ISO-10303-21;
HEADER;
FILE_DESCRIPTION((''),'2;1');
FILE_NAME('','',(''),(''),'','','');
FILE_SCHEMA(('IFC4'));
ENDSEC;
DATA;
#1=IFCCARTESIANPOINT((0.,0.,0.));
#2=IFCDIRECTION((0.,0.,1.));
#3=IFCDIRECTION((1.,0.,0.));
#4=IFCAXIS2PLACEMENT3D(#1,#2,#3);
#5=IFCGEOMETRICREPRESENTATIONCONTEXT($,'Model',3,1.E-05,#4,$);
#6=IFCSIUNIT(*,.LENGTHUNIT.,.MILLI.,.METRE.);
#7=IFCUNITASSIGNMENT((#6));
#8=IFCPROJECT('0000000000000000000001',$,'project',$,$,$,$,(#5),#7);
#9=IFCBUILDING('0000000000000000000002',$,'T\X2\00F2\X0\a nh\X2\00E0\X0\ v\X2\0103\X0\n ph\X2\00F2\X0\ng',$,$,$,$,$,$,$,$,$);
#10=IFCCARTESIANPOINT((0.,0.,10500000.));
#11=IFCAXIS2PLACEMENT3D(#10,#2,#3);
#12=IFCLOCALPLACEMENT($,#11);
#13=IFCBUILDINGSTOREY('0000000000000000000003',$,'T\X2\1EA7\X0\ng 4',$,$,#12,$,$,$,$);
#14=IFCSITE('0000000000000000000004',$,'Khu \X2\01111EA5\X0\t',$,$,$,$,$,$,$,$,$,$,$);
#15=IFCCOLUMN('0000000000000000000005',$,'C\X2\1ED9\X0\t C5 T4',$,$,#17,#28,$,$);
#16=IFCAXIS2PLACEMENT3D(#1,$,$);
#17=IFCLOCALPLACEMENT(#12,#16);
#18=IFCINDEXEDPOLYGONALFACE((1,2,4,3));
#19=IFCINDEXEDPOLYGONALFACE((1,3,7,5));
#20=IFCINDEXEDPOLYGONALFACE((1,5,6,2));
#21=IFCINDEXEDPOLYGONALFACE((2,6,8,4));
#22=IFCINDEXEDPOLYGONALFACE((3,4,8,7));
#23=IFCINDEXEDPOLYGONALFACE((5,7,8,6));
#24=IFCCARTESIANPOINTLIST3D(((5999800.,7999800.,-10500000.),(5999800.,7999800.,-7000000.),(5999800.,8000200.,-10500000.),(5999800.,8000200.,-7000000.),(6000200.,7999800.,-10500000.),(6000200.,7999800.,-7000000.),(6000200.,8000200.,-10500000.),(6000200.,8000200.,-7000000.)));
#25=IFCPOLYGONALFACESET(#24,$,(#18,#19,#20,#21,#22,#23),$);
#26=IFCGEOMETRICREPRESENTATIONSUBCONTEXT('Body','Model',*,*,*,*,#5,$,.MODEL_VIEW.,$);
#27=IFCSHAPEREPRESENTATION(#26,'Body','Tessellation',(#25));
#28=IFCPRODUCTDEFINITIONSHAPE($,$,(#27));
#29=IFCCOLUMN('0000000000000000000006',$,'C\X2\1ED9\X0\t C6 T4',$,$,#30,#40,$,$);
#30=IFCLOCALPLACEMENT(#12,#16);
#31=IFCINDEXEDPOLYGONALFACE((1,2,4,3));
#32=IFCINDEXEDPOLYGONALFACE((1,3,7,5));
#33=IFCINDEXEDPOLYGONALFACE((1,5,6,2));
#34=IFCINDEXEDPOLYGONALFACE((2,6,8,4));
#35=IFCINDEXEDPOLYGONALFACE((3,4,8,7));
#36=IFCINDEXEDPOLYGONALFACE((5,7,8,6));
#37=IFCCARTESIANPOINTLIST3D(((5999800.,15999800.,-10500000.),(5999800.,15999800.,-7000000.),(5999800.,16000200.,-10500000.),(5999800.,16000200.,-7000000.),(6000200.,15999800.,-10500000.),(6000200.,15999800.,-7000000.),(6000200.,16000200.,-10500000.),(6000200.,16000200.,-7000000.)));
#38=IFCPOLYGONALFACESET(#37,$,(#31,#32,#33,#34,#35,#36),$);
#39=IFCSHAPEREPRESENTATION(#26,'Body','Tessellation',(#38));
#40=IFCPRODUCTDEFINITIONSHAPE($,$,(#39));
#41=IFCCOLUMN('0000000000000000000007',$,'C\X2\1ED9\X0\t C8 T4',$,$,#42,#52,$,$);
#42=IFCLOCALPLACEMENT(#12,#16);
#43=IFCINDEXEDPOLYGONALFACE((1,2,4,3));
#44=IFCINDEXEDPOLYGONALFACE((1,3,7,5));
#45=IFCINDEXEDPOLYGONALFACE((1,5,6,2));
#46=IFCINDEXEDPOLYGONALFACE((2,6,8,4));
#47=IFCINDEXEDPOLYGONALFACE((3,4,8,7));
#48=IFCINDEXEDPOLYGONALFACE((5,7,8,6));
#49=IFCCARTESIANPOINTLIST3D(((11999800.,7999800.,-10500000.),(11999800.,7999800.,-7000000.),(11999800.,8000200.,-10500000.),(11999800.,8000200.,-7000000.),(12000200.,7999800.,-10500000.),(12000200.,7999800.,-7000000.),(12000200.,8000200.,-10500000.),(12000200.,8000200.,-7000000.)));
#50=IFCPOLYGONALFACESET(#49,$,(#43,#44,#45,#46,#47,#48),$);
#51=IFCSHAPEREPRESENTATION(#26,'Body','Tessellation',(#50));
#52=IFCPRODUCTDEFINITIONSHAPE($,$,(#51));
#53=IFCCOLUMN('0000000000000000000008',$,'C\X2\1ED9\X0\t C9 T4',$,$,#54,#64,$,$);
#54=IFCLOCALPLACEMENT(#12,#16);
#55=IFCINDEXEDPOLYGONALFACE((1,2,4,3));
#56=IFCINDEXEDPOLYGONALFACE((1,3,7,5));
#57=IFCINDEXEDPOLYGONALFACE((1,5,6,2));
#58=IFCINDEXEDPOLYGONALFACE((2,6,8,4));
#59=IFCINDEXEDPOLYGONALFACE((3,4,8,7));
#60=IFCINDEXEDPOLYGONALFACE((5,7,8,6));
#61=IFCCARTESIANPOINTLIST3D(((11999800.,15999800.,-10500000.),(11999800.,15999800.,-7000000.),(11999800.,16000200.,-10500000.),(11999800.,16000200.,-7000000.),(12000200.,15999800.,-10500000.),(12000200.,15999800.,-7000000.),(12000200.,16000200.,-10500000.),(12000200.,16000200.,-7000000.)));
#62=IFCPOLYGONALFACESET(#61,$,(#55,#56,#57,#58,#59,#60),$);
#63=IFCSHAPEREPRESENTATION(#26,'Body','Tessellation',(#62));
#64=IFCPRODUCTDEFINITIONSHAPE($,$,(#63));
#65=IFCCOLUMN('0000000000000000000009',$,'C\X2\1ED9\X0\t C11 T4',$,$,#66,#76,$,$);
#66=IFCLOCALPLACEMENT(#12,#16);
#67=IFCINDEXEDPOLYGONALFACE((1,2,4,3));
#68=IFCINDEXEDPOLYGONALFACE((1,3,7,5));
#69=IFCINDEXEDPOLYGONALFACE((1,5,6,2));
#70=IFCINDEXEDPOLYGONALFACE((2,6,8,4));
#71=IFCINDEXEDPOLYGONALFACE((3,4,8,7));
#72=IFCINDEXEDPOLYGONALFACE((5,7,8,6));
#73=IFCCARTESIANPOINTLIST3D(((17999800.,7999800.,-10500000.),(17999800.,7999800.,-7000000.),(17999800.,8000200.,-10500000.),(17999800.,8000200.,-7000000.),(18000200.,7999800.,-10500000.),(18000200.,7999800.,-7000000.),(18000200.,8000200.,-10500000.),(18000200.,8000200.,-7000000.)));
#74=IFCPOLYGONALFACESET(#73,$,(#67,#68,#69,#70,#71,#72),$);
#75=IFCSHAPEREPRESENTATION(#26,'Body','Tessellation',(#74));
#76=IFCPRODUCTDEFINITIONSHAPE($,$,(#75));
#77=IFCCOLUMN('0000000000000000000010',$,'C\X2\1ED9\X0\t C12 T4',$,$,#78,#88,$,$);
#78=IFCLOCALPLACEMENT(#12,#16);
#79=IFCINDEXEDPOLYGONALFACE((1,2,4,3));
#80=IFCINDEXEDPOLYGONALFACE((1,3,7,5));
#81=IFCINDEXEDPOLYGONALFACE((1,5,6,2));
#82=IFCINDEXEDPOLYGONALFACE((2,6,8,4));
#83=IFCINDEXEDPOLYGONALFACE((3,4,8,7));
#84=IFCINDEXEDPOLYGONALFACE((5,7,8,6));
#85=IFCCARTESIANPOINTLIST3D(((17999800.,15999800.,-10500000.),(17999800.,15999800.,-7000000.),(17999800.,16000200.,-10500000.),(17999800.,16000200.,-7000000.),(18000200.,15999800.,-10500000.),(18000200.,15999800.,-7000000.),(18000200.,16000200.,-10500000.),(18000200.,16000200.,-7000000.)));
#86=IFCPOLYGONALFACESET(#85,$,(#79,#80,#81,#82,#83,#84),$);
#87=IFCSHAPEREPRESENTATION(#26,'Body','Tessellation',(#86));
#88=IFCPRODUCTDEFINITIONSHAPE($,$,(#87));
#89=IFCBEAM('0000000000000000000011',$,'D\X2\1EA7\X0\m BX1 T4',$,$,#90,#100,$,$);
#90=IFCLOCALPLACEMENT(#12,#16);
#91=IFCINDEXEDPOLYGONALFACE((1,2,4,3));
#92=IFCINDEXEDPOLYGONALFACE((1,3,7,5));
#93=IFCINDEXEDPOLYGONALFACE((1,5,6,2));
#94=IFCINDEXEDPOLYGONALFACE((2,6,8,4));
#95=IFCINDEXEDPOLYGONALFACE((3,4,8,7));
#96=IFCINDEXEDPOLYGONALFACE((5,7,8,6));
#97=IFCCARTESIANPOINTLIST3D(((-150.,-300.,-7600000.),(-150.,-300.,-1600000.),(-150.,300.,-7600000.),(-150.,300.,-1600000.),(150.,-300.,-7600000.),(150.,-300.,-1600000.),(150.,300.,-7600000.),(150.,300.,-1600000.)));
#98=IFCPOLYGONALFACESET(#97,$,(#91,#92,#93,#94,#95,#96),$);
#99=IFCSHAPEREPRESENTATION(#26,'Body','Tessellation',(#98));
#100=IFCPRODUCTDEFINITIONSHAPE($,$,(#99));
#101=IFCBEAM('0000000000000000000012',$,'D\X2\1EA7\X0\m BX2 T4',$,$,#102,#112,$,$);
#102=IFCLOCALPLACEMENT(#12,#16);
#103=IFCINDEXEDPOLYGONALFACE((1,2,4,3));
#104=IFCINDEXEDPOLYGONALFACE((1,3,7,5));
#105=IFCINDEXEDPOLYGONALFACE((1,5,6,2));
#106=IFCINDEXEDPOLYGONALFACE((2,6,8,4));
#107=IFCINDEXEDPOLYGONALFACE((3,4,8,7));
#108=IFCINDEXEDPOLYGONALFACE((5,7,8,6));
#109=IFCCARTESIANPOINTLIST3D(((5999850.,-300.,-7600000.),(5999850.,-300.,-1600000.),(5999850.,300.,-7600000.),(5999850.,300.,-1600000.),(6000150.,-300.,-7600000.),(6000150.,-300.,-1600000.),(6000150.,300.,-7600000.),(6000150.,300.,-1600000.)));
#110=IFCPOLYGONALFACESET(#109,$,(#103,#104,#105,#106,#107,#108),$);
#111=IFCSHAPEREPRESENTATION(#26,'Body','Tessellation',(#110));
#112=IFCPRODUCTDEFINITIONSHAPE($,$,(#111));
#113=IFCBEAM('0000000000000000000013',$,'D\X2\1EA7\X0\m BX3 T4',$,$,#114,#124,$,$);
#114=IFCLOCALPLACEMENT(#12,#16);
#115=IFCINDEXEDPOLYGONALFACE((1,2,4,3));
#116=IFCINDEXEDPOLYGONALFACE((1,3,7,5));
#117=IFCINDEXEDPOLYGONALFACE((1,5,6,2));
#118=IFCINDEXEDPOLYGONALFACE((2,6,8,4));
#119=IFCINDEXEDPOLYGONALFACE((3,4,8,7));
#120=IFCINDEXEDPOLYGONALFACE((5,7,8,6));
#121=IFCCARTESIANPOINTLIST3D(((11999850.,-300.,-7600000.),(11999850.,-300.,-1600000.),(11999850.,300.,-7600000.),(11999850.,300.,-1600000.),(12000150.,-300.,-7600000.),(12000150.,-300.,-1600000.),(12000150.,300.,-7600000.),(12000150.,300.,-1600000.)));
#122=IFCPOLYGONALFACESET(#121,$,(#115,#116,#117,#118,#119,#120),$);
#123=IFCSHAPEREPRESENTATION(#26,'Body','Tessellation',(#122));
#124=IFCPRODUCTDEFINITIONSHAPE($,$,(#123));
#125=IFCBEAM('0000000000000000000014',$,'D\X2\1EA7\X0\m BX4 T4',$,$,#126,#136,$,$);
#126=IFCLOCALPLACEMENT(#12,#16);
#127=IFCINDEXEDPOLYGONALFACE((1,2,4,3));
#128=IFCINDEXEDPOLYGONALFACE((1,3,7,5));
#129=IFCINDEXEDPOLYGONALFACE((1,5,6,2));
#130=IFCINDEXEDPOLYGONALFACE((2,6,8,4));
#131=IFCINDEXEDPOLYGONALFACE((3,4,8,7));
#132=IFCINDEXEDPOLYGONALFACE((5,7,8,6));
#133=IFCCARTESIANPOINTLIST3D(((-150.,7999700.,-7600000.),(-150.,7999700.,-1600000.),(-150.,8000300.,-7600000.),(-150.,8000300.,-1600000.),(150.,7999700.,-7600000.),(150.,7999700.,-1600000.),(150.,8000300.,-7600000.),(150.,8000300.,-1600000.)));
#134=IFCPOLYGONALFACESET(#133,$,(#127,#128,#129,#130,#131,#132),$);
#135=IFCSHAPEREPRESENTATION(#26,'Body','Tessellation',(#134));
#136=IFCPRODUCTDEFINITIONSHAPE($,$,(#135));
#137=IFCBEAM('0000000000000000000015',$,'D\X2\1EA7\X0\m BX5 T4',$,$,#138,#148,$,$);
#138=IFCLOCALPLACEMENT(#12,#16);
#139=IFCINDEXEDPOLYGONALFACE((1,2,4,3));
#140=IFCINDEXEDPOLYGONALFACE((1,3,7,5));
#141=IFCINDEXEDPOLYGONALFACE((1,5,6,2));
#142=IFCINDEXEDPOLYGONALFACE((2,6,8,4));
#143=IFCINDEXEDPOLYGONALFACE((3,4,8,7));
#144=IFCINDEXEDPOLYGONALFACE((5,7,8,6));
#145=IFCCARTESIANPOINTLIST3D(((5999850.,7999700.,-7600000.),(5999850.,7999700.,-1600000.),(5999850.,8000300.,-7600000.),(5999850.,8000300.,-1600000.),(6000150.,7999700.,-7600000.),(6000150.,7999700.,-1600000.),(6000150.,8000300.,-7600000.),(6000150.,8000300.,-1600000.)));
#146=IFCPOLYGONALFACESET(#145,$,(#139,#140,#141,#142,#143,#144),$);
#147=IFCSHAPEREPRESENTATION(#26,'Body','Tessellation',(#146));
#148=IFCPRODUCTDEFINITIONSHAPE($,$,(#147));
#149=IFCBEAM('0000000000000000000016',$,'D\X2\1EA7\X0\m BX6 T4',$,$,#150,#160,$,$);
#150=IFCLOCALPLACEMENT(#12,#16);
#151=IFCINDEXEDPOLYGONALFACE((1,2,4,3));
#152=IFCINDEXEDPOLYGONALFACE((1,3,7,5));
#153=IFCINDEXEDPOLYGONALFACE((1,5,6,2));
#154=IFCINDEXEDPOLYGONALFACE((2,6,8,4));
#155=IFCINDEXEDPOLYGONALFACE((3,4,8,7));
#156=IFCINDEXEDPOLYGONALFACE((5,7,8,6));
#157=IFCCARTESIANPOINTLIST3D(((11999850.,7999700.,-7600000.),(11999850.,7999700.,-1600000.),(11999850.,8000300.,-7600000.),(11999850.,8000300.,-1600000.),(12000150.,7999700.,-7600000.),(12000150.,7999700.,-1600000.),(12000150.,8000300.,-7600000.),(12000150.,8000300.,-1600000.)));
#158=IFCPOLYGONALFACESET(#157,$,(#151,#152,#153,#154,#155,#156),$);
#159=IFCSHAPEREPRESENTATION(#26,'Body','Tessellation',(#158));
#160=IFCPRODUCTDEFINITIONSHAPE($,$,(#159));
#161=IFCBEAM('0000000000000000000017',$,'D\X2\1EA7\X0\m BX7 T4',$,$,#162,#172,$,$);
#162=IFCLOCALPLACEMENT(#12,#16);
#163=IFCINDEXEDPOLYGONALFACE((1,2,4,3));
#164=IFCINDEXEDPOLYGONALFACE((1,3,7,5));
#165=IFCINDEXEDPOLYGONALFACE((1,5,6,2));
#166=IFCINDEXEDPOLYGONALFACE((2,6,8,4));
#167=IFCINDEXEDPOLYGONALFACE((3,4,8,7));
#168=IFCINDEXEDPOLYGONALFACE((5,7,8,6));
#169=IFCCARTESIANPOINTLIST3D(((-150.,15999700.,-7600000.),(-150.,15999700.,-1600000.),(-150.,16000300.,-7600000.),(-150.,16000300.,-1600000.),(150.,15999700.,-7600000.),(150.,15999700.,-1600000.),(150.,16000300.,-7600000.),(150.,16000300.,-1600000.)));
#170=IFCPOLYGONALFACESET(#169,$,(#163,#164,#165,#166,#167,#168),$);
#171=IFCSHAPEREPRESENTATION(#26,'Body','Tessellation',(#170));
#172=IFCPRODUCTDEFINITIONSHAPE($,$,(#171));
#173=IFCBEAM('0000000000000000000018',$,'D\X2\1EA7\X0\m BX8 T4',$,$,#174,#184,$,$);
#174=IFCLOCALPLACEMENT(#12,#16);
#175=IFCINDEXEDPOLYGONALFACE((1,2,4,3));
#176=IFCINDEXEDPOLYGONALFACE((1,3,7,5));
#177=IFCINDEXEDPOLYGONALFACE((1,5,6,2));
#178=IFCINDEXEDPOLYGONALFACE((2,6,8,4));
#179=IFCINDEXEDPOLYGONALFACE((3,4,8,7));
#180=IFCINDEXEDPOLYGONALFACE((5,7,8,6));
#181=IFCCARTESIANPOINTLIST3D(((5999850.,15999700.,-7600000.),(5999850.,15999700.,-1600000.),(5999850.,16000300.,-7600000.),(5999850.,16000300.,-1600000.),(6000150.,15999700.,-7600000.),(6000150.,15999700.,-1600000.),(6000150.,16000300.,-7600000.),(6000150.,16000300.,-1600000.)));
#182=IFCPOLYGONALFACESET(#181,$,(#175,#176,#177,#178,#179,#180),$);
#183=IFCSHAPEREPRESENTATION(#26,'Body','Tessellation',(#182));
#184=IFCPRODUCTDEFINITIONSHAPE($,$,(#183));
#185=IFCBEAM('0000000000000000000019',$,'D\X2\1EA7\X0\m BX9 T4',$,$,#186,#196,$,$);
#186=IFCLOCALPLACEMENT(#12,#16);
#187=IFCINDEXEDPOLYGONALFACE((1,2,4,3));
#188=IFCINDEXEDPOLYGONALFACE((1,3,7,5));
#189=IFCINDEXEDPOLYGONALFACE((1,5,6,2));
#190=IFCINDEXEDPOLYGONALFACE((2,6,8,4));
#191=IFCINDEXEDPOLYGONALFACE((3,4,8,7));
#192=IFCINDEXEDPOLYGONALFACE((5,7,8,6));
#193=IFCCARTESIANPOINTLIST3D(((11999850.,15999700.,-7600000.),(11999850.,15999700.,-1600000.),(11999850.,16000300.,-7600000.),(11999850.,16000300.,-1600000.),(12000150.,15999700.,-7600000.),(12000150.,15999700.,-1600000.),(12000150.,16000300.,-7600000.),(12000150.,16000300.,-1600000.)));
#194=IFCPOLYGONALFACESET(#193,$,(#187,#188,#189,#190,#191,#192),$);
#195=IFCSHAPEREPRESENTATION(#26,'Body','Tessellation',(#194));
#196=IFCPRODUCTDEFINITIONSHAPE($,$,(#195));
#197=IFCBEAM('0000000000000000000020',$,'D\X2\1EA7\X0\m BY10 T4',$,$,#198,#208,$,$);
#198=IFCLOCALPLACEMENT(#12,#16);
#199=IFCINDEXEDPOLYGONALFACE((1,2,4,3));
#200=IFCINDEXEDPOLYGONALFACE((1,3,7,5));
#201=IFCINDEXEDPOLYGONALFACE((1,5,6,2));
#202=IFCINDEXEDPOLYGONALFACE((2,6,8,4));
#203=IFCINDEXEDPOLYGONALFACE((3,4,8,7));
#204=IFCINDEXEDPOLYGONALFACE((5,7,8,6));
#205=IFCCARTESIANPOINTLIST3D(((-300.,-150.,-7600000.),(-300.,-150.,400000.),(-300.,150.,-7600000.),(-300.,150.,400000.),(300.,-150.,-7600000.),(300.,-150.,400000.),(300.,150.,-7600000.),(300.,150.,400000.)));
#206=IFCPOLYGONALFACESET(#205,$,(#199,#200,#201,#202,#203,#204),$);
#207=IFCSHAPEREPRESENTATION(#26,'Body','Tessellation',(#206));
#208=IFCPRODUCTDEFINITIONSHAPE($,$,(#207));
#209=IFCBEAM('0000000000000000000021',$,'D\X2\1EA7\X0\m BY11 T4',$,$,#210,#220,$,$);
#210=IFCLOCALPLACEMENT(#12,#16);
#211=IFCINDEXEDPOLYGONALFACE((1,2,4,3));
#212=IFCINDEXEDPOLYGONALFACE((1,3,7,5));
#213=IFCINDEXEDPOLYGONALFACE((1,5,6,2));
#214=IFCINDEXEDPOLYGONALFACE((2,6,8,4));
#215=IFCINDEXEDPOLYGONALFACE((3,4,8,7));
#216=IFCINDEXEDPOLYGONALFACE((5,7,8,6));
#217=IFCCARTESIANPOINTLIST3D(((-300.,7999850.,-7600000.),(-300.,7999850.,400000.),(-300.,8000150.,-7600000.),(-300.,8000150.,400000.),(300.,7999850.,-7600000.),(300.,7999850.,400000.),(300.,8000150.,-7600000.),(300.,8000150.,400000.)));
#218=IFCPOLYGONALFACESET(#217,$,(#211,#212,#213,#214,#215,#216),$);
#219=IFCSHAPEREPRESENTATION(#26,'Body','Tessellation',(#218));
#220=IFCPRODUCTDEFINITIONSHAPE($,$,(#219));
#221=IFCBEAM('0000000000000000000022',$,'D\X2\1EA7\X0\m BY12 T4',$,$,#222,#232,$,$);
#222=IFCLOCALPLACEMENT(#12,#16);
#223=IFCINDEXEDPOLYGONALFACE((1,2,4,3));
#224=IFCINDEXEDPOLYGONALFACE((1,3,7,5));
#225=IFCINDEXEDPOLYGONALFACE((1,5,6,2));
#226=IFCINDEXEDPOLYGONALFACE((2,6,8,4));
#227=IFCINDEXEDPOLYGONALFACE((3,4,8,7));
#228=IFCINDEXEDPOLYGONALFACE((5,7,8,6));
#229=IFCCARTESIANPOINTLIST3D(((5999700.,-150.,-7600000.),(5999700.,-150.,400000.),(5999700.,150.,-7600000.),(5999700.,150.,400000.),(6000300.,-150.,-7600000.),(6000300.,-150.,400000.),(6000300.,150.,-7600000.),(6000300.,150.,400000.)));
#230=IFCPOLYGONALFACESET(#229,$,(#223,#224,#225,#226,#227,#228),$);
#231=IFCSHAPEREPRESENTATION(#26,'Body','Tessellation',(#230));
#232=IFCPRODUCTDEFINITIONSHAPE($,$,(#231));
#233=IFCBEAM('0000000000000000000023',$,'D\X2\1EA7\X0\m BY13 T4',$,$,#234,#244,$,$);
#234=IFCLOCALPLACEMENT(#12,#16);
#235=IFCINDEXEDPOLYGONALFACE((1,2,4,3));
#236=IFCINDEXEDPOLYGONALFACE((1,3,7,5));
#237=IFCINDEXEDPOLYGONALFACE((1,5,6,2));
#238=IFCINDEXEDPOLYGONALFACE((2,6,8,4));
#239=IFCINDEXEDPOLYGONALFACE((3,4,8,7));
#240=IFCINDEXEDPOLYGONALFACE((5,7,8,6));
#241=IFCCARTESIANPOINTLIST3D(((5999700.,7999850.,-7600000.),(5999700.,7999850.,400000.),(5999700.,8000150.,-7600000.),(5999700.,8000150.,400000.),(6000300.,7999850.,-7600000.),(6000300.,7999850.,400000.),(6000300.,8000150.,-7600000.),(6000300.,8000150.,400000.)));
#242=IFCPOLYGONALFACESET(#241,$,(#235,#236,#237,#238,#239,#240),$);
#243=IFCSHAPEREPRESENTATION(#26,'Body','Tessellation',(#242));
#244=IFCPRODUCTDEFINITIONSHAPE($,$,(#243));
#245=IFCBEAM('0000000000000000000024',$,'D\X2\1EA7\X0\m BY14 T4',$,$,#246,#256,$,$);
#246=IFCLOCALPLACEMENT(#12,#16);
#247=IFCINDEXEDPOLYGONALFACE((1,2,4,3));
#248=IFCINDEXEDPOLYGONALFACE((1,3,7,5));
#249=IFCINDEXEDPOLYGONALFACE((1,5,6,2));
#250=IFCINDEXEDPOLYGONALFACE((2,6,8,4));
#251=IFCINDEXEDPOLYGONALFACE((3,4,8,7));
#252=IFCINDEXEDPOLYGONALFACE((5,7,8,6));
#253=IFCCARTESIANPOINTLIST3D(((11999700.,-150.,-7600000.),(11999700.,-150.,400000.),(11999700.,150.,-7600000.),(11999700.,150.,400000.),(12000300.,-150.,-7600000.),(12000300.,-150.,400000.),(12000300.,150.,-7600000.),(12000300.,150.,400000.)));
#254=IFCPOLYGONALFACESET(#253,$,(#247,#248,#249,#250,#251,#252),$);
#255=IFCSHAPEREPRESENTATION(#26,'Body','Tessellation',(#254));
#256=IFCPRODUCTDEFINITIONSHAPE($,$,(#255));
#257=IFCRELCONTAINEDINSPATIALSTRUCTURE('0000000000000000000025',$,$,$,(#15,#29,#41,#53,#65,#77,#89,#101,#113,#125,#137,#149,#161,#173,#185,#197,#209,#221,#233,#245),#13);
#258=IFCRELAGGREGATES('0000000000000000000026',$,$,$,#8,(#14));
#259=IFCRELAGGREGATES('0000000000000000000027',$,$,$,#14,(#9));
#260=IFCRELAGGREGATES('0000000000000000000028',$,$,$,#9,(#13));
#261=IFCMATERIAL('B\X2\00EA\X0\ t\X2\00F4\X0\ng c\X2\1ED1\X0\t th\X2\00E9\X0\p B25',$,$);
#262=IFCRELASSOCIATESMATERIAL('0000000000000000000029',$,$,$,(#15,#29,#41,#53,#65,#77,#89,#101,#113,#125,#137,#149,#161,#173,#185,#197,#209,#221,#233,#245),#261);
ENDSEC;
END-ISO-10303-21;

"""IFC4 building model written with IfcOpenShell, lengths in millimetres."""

from ifc_helpers import new_model, entity, si_unit, frame, origin_with_axes, place, context, subcontext, project, spatial, extrude, material, element, save


model = new_model("IFC4")

# Units and contexts
model_context = context("Model", 3, precision=1e-05, world=origin_with_axes())
body_context = subcontext(model_context, "Body", "Model", "MODEL_VIEW")
ifc_project = project(units=[si_unit("LENGTHUNIT", "METRE", prefix="MILLI")], contexts=[model_context])

# Site, building, storey
site = spatial("IfcSite", under=ifc_project, Name="Khu đất")
building = spatial("IfcBuilding", under=site, Name="Tòa nhà văn phòng")
storey_placement = place(None, frame((0.0, 0.0, 10500000.0), z_axis=(0.0, 0.0, 1.0), x_axis=(1.0, 0.0, 0.0)))
storey = spatial("IfcBuildingStorey", under=building, at=storey_placement, Name="Tầng 4")

# Columns
ifc_material_1 = material(Name="Bê tông cốt thép B25")
for number, where, z_axis, x_axis, name in (
    (1, (6000000.0, 8000000.0, -10500000.0), (0.0, 0.0, 1.0), (1.0, 0.0, 0.0), "Cột C5 T4"),
    (2, (6000000.0, 16000000.0, -10500000.0), (0.0, 0.0, 1.0), (1.0, 0.0, 0.0), "Cột C6 T4"),
    (3, (12000000.0, 8000000.0, -10500000.0), (0.0, 0.0, 1.0), (1.0, 0.0, 0.0), "Cột C8 T4"),
    (4, (12000000.0, 16000000.0, -10500000.0), (0.0, 0.0, 1.0), (1.0, 0.0, 0.0), "Cột C9 T4"),
    (5, (18000000.0, 8000000.0, -10500000.0), (0.0, 0.0, 1.0), (1.0, 0.0, 0.0), "Cột C11 T4"),
    (6, (18000000.0, 16000000.0, -10500000.0), (0.0, 0.0, 1.0), (1.0, 0.0, 0.0), "Cột C12 T4"),
):
    element("IfcColumn", number, at=place(storey_placement, frame(where, z_axis=z_axis, x_axis=x_axis)), inside=storey, material=ifc_material_1, Name=name, context=body_context, shape_type="SweptSolid", body=[
        extrude(entity("IfcRectangleProfileDef", None, None, None, 400.0, 400.0), origin_with_axes(), (0.0, 0.0, 1.0), 3500000.0),
    ])

# Beams
for number, where, z_axis, x_axis, name in (
    (7, (0.0, 0.0, -7600000.0), (0.0, 0.0, 1.0), (1.0, 0.0, 0.0), "Dầm BX1 T4"),
    (8, (6000000.0, 0.0, -7600000.0), (0.0, 0.0, 1.0), (1.0, 0.0, 0.0), "Dầm BX2 T4"),
    (9, (12000000.0, 0.0, -7600000.0), (0.0, 0.0, 1.0), (1.0, 0.0, 0.0), "Dầm BX3 T4"),
    (10, (0.0, 8000000.0, -7600000.0), (0.0, 0.0, 1.0), (1.0, 0.0, 0.0), "Dầm BX4 T4"),
    (11, (6000000.0, 8000000.0, -7600000.0), (0.0, 0.0, 1.0), (1.0, 0.0, 0.0), "Dầm BX5 T4"),
    (12, (12000000.0, 8000000.0, -7600000.0), (0.0, 0.0, 1.0), (1.0, 0.0, 0.0), "Dầm BX6 T4"),
    (13, (0.0, 16000000.0, -7600000.0), (0.0, 0.0, 1.0), (1.0, 0.0, 0.0), "Dầm BX7 T4"),
    (14, (6000000.0, 16000000.0, -7600000.0), (0.0, 0.0, 1.0), (1.0, 0.0, 0.0), "Dầm BX8 T4"),
    (15, (12000000.0, 16000000.0, -7600000.0), (0.0, 0.0, 1.0), (1.0, 0.0, 0.0), "Dầm BX9 T4"),
):
    element("IfcBeam", number, at=place(storey_placement, frame(where, z_axis=z_axis, x_axis=x_axis)), inside=storey, material=ifc_material_1, Name=name, context=body_context, shape_type="SweptSolid", body=[
        extrude(entity("IfcRectangleProfileDef", None, None, None, 300.0, 600.0), origin_with_axes(), (0.0, 0.0, 1.0), 6000000.0),
    ])
for number, where, z_axis, x_axis, name in (
    (16, (0.0, 0.0, -7600000.0), (0.0, 0.0, 1.0), (0.0, 1.0, 0.0), "Dầm BY10 T4"),
    (17, (0.0, 8000000.0, -7600000.0), (0.0, 0.0, 1.0), (0.0, 1.0, 0.0), "Dầm BY11 T4"),
    (18, (6000000.0, 0.0, -7600000.0), (0.0, 0.0, 1.0), (0.0, 1.0, 0.0), "Dầm BY12 T4"),
    (19, (6000000.0, 8000000.0, -7600000.0), (0.0, 0.0, 1.0), (0.0, 1.0, 0.0), "Dầm BY13 T4"),
    (20, (12000000.0, 0.0, -7600000.0), (0.0, 0.0, 1.0), (0.0, 1.0, 0.0), "Dầm BY14 T4"),
):
    element("IfcBeam", number, at=place(storey_placement, frame(where, z_axis=z_axis, x_axis=x_axis)), inside=storey, material=ifc_material_1, Name=name, context=body_context, shape_type="SweptSolid", body=[
        extrude(entity("IfcRectangleProfileDef", None, None, None, 300.0, 600.0), origin_with_axes(), (0.0, 0.0, 1.0), 8000000.0),
    ])

save(model, "model.ifc")
